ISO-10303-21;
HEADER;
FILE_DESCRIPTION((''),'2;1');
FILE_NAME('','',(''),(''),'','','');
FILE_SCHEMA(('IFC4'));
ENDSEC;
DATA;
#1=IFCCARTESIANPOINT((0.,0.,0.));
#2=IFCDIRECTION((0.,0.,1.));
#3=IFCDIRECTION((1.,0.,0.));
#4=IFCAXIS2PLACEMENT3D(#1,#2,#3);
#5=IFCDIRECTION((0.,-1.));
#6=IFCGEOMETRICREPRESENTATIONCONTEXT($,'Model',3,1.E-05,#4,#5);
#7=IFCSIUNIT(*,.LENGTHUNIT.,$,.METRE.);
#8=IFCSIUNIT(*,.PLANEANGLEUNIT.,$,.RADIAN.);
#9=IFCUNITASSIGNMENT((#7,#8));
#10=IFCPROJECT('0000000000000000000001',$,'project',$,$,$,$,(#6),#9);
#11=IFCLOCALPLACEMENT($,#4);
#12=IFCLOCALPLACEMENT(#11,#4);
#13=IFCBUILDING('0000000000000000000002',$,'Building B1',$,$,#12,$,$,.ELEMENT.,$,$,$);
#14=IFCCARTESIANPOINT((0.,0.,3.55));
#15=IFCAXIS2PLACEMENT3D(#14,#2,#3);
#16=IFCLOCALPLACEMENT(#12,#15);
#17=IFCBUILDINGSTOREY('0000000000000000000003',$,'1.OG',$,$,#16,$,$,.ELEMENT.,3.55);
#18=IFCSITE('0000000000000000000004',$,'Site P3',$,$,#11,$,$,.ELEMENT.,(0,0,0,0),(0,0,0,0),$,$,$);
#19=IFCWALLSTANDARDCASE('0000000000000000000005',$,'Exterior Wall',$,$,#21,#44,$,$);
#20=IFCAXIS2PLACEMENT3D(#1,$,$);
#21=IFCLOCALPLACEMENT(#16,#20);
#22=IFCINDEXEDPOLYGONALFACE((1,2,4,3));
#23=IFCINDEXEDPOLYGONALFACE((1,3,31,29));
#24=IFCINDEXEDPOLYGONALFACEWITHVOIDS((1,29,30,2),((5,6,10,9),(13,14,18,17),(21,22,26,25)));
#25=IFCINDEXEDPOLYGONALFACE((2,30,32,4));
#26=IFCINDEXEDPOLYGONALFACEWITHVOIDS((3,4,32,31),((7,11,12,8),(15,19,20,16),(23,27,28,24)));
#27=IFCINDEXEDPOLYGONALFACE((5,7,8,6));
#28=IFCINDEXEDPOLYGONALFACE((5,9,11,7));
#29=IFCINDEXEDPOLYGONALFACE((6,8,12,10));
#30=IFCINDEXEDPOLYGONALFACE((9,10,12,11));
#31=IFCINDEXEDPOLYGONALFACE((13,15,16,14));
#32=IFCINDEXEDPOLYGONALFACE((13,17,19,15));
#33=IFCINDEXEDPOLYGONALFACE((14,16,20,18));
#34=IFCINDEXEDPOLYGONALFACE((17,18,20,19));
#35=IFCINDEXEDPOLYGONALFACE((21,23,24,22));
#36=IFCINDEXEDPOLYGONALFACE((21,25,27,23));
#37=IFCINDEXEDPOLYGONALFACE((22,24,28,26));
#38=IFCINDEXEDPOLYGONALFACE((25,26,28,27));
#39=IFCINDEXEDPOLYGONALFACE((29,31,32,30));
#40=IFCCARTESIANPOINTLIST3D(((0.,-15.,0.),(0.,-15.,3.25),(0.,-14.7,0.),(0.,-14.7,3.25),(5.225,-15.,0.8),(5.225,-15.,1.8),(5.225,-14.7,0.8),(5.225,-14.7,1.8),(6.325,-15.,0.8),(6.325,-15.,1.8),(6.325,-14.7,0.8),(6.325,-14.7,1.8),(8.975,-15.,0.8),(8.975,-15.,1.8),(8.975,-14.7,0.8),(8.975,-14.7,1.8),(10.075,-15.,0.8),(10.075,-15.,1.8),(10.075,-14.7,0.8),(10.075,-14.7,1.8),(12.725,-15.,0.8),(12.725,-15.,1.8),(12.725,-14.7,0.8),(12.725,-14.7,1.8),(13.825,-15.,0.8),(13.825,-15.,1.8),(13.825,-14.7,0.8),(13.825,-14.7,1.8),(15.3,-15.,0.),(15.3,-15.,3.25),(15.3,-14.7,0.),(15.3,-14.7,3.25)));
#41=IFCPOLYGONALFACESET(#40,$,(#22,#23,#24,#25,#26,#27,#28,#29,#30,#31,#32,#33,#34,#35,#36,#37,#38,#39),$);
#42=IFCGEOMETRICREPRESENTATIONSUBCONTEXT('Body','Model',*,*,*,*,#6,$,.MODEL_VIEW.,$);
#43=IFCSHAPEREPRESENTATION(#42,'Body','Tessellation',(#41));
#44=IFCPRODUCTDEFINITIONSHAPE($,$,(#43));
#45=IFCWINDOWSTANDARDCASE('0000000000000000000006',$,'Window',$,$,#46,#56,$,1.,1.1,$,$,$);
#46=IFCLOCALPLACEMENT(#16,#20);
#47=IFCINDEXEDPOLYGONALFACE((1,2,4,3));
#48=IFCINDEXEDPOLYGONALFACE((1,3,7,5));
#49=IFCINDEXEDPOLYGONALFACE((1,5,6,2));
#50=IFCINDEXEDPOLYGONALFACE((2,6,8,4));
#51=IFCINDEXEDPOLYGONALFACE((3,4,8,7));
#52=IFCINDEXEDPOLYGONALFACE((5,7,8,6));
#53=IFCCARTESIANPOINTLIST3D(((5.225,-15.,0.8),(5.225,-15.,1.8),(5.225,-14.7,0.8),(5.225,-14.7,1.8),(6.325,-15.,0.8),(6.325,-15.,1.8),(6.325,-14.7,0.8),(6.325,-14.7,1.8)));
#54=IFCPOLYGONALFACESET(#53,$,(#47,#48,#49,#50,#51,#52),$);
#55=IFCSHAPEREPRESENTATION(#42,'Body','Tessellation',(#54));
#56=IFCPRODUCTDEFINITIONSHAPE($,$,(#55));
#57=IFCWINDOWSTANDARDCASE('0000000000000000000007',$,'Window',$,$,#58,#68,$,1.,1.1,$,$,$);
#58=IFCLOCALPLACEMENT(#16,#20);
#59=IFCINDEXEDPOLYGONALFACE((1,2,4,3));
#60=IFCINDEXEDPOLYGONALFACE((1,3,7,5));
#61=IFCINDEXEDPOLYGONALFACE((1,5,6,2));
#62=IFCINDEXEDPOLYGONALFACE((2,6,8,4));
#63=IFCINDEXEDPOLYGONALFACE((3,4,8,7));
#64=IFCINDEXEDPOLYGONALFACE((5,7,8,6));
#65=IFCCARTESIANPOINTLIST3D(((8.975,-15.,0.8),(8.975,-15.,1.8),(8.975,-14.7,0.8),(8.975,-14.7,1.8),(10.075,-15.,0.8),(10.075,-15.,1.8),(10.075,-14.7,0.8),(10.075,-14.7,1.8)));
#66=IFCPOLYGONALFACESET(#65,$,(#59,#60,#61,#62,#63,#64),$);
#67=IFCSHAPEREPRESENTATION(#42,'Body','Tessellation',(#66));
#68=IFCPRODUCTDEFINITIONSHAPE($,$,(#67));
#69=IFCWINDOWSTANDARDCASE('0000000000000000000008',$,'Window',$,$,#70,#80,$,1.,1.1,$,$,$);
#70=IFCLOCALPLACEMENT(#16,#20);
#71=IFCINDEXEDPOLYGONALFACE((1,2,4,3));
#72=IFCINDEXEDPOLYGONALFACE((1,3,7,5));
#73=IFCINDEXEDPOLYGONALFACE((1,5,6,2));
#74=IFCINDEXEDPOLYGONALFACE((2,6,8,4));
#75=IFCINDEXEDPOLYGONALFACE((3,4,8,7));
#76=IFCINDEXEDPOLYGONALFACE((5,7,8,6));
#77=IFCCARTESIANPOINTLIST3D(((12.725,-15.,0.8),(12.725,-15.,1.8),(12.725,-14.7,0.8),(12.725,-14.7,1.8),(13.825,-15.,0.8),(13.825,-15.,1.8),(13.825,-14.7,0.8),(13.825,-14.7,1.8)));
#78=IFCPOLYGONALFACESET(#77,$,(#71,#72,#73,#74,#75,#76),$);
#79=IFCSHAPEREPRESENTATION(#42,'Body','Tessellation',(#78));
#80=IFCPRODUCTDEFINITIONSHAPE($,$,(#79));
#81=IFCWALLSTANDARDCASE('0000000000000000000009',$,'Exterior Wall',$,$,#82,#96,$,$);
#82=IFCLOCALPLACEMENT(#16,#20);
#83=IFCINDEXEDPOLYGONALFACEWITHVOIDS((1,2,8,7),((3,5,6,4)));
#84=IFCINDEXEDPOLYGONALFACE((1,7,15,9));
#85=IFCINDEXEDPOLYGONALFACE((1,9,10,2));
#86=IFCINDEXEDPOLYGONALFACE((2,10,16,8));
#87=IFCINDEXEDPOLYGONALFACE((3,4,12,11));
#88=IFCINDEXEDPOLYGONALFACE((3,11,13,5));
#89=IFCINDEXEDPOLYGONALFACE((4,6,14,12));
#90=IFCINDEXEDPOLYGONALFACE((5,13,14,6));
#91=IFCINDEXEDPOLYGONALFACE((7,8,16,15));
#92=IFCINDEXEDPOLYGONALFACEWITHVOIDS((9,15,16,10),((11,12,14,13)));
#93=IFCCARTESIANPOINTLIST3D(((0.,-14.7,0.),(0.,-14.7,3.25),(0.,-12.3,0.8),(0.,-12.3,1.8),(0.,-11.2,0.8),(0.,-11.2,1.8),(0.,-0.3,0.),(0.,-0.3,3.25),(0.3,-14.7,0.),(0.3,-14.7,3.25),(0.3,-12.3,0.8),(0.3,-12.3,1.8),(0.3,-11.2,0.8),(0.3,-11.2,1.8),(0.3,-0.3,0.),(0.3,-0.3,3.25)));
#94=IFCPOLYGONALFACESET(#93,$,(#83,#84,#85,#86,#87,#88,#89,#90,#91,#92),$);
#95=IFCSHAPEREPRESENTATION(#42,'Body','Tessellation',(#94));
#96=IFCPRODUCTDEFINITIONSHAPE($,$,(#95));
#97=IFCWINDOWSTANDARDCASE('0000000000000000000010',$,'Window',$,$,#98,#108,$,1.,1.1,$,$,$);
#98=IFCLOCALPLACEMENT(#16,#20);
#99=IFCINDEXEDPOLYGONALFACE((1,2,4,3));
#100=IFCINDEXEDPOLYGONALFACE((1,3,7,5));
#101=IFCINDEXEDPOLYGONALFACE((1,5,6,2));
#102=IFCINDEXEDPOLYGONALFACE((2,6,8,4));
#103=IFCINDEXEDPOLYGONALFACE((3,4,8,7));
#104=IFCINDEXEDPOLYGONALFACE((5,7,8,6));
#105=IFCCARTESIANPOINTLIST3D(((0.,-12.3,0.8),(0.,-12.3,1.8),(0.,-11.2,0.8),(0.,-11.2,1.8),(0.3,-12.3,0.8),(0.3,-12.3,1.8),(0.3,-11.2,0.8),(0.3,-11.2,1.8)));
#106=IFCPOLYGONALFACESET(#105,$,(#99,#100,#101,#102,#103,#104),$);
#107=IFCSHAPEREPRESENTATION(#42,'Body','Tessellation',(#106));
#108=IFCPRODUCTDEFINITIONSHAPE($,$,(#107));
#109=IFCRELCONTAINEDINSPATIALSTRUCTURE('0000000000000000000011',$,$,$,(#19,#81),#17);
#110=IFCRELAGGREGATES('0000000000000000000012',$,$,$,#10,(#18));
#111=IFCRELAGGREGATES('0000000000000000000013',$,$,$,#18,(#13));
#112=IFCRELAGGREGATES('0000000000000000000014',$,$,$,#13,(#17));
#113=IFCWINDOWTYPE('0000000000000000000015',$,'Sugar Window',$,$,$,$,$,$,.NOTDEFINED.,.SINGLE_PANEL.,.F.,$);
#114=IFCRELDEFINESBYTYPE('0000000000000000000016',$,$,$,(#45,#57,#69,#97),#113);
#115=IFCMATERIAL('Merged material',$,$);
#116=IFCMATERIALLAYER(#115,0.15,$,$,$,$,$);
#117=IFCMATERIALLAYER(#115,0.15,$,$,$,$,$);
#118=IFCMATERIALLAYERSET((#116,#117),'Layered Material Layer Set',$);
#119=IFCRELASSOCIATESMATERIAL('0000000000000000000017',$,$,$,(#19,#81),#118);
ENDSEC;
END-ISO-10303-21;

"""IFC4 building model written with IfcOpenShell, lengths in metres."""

from ifc_helpers import new_model, si_unit, direction, frame, origin_with_axes, place, context, subcontext, project, spatial, polyline, outline, extrude, source, transform, mapped, material, layer, layer_set, layer_usage, type_object, element, fill, save


model = new_model("IFC4")

# Units and contexts
model_context = context("Model", 3, precision=1e-05, world=origin_with_axes(), true_north=direction((0.0, -1.0)))
body_context = subcontext(model_context, "Body", "Model", "MODEL_VIEW")
ifc_project = project(units=[si_unit("LENGTHUNIT", "METRE"), si_unit("PLANEANGLEUNIT", "RADIAN")], contexts=[model_context])

# Site, building, storey
site_placement = place(None, origin_with_axes())
site = spatial("IfcSite", under=ifc_project, at=site_placement, Name="Site P3", CompositionType="ELEMENT", RefLatitude=(0, 0, 0, 0), RefLongitude=(0, 0, 0, 0))
building_placement = place(site_placement, origin_with_axes())
building = spatial("IfcBuilding", under=site, at=building_placement, Name="Building B1", CompositionType="ELEMENT")
storey_placement = place(building_placement, frame((0.0, 0.0, 3.55), z_axis=(0.0, 0.0, 1.0), x_axis=(1.0, 0.0, 0.0)))
storey = spatial("IfcBuildingStorey", under=building, at=storey_placement, Name="1.OG", CompositionType="ELEMENT", Elevation=3.55)

# Wall, openings, windows
ifc_material = material(Name="Merged material")
ifc_layer_1 = layer(ifc_material, 0.15)
ifc_layer_2 = layer(ifc_material, 0.15)
ifc_layer_set_1 = layer_set([ifc_layer_1, ifc_layer_2], Name="Layered Material Layer Set")
ifc_layer_usage_1 = layer_usage(ifc_layer_set_1, "AXIS2", "POSITIVE", -0.15)
wall_1_placement = place(storey_placement, frame((0.0, -14.85, 0.0), z_axis=(0.0, 0.0, 1.0), x_axis=(1.0, 0.0, 0.0)))
wall_1 = element("IfcWallStandardCase", 1, at=wall_1_placement, inside=storey, material=ifc_layer_usage_1, Name="Exterior Wall", context=body_context, shape_type="SweptSolid", body=[
    extrude(outline(polyline([(0.0, 0.15), (15.3, 0.15), (15.3, -0.15), (0.0, -0.15), (0.0, 0.15)])), origin_with_axes(), (0.0, 0.0, 1.0), 3.25),
])
opening_1_placement = place(wall_1_placement, frame((5.225, 0.0, 0.8), z_axis=(0.0, 0.0, 1.0), x_axis=(1.0, 0.0, 0.0)))
opening_1 = element("IfcOpeningStandardCase", 2, at=opening_1_placement, cuts=wall_1, context=body_context, shape_type="SweptSolid", body=[
    extrude(outline(polyline([(0.0, 0.0), (0.0, 1.1), (1.0, 1.1), (1.0, 0.0), (0.0, 0.0)])), frame((0.0, -0.15, 0.0), z_axis=(0.0, 1.0, 0.0), x_axis=(0.0, 0.0, 1.0)), (0.0, 0.0, 1.0), 0.3),
])
opening_2_placement = place(wall_1_placement, frame((8.975, 0.0, 0.8), z_axis=(0.0, 0.0, 1.0), x_axis=(1.0, 0.0, 0.0)))
opening_2 = element("IfcOpeningStandardCase", 3, at=opening_2_placement, cuts=wall_1, context=body_context, shape_type="SweptSolid", body=[
    extrude(outline(polyline([(0.0, 0.0), (0.0, 1.1), (1.0, 1.1), (1.0, 0.0), (0.0, 0.0)])), frame((0.0, -0.15, 0.0), z_axis=(0.0, 1.0, 0.0), x_axis=(0.0, 0.0, 1.0)), (0.0, 0.0, 1.0), 0.3),
])
opening_3_placement = place(wall_1_placement, frame((12.725, 0.0, 0.8), z_axis=(0.0, 0.0, 1.0), x_axis=(1.0, 0.0, 0.0)))
opening_3 = element("IfcOpeningStandardCase", 4, at=opening_3_placement, cuts=wall_1, context=body_context, shape_type="SweptSolid", body=[
    extrude(outline(polyline([(0.0, 0.0), (0.0, 1.1), (1.0, 1.1), (1.0, 0.0), (0.0, 0.0)])), frame((0.0, -0.15, 0.0), z_axis=(0.0, 1.0, 0.0), x_axis=(0.0, 0.0, 1.0)), (0.0, 0.0, 1.0), 0.3),
])
window_type = type_object("IfcWindowType", Name="Sugar Window", ParameterTakesPrecedence=False, PartitioningType="SINGLE_PANEL", PredefinedType="NOTDEFINED")
shared_shape_1 = source(origin_with_axes(), body_context, "Body", "SweptSolid", [
    extrude(outline(polyline([(0.0, 0.0), (0.0, 1.1), (1.0, 1.1), (1.0, 0.0), (0.0, 0.0)])), frame((0.0, -0.15, 0.0), z_axis=(0.0, 1.0, 0.0), x_axis=(0.0, 0.0, 1.0)), (0.0, 0.0, 1.0), 0.3),
])
window_1_placement = place(opening_1_placement, origin_with_axes())
window_1 = element("IfcWindowStandardCase", 5, at=window_1_placement, type_object=window_type, Name="Window", OverallHeight=1.0, OverallWidth=1.1, context=body_context, shape_type="MappedRepresentation", body=[
    mapped(shared_shape_1, transform((0.0, 0.0, 0.0))),
])
fill(opening_1, window_1)
window_2_placement = place(opening_2_placement, origin_with_axes())
window_2 = element("IfcWindowStandardCase", 6, at=window_2_placement, type_object=window_type, Name="Window", OverallHeight=1.0, OverallWidth=1.1, context=body_context, shape_type="MappedRepresentation", body=[
    mapped(shared_shape_1, transform((0.0, 0.0, 0.0))),
])
fill(opening_2, window_2)
window_3_placement = place(opening_3_placement, origin_with_axes())
window_3 = element("IfcWindowStandardCase", 7, at=window_3_placement, type_object=window_type, Name="Window", OverallHeight=1.0, OverallWidth=1.1, context=body_context, shape_type="MappedRepresentation", body=[
    mapped(shared_shape_1, transform((0.0, 0.0, 0.0))),
])
fill(opening_3, window_3)

# Wall, opening, window
wall_2_placement = place(storey_placement, frame((0.15, -0.3, 0.0), z_axis=(0.0, 0.0, 1.0), x_axis=(0.0, -1.0, 0.0)))
wall_2 = element("IfcWallStandardCase", 8, at=wall_2_placement, inside=storey, material=ifc_layer_usage_1, Name="Exterior Wall", context=body_context, shape_type="SweptSolid", body=[
    extrude(outline(polyline([(0.0, 0.15), (14.4, 0.15), (14.4, -0.15), (0.0, -0.15), (0.0, 0.15)])), origin_with_axes(), (0.0, 0.0, 1.0), 3.25),
])
opening_4_placement = place(wall_2_placement, frame((10.9, 0.0, 0.8), z_axis=(0.0, 0.0, 1.0), x_axis=(1.0, 0.0, 0.0)))
opening_4 = element("IfcOpeningStandardCase", 9, at=opening_4_placement, cuts=wall_2, context=body_context, shape_type="SweptSolid", body=[
    extrude(outline(polyline([(0.0, 0.0), (0.0, 1.1), (1.0, 1.1), (1.0, 0.0), (0.0, 0.0)])), frame((0.0, -0.15, 0.0), z_axis=(0.0, 1.0, 0.0), x_axis=(0.0, 0.0, 1.0)), (0.0, 0.0, 1.0), 0.3),
])
window_4_placement = place(opening_4_placement, origin_with_axes())
window_4 = element("IfcWindowStandardCase", 10, at=window_4_placement, type_object=window_type, Name="Window", OverallHeight=1.0, OverallWidth=1.1, context=body_context, shape_type="MappedRepresentation", body=[
    mapped(shared_shape_1, transform((0.0, 0.0, 0.0))),
])
fill(opening_4, window_4)

save(model, "model.ifc")
